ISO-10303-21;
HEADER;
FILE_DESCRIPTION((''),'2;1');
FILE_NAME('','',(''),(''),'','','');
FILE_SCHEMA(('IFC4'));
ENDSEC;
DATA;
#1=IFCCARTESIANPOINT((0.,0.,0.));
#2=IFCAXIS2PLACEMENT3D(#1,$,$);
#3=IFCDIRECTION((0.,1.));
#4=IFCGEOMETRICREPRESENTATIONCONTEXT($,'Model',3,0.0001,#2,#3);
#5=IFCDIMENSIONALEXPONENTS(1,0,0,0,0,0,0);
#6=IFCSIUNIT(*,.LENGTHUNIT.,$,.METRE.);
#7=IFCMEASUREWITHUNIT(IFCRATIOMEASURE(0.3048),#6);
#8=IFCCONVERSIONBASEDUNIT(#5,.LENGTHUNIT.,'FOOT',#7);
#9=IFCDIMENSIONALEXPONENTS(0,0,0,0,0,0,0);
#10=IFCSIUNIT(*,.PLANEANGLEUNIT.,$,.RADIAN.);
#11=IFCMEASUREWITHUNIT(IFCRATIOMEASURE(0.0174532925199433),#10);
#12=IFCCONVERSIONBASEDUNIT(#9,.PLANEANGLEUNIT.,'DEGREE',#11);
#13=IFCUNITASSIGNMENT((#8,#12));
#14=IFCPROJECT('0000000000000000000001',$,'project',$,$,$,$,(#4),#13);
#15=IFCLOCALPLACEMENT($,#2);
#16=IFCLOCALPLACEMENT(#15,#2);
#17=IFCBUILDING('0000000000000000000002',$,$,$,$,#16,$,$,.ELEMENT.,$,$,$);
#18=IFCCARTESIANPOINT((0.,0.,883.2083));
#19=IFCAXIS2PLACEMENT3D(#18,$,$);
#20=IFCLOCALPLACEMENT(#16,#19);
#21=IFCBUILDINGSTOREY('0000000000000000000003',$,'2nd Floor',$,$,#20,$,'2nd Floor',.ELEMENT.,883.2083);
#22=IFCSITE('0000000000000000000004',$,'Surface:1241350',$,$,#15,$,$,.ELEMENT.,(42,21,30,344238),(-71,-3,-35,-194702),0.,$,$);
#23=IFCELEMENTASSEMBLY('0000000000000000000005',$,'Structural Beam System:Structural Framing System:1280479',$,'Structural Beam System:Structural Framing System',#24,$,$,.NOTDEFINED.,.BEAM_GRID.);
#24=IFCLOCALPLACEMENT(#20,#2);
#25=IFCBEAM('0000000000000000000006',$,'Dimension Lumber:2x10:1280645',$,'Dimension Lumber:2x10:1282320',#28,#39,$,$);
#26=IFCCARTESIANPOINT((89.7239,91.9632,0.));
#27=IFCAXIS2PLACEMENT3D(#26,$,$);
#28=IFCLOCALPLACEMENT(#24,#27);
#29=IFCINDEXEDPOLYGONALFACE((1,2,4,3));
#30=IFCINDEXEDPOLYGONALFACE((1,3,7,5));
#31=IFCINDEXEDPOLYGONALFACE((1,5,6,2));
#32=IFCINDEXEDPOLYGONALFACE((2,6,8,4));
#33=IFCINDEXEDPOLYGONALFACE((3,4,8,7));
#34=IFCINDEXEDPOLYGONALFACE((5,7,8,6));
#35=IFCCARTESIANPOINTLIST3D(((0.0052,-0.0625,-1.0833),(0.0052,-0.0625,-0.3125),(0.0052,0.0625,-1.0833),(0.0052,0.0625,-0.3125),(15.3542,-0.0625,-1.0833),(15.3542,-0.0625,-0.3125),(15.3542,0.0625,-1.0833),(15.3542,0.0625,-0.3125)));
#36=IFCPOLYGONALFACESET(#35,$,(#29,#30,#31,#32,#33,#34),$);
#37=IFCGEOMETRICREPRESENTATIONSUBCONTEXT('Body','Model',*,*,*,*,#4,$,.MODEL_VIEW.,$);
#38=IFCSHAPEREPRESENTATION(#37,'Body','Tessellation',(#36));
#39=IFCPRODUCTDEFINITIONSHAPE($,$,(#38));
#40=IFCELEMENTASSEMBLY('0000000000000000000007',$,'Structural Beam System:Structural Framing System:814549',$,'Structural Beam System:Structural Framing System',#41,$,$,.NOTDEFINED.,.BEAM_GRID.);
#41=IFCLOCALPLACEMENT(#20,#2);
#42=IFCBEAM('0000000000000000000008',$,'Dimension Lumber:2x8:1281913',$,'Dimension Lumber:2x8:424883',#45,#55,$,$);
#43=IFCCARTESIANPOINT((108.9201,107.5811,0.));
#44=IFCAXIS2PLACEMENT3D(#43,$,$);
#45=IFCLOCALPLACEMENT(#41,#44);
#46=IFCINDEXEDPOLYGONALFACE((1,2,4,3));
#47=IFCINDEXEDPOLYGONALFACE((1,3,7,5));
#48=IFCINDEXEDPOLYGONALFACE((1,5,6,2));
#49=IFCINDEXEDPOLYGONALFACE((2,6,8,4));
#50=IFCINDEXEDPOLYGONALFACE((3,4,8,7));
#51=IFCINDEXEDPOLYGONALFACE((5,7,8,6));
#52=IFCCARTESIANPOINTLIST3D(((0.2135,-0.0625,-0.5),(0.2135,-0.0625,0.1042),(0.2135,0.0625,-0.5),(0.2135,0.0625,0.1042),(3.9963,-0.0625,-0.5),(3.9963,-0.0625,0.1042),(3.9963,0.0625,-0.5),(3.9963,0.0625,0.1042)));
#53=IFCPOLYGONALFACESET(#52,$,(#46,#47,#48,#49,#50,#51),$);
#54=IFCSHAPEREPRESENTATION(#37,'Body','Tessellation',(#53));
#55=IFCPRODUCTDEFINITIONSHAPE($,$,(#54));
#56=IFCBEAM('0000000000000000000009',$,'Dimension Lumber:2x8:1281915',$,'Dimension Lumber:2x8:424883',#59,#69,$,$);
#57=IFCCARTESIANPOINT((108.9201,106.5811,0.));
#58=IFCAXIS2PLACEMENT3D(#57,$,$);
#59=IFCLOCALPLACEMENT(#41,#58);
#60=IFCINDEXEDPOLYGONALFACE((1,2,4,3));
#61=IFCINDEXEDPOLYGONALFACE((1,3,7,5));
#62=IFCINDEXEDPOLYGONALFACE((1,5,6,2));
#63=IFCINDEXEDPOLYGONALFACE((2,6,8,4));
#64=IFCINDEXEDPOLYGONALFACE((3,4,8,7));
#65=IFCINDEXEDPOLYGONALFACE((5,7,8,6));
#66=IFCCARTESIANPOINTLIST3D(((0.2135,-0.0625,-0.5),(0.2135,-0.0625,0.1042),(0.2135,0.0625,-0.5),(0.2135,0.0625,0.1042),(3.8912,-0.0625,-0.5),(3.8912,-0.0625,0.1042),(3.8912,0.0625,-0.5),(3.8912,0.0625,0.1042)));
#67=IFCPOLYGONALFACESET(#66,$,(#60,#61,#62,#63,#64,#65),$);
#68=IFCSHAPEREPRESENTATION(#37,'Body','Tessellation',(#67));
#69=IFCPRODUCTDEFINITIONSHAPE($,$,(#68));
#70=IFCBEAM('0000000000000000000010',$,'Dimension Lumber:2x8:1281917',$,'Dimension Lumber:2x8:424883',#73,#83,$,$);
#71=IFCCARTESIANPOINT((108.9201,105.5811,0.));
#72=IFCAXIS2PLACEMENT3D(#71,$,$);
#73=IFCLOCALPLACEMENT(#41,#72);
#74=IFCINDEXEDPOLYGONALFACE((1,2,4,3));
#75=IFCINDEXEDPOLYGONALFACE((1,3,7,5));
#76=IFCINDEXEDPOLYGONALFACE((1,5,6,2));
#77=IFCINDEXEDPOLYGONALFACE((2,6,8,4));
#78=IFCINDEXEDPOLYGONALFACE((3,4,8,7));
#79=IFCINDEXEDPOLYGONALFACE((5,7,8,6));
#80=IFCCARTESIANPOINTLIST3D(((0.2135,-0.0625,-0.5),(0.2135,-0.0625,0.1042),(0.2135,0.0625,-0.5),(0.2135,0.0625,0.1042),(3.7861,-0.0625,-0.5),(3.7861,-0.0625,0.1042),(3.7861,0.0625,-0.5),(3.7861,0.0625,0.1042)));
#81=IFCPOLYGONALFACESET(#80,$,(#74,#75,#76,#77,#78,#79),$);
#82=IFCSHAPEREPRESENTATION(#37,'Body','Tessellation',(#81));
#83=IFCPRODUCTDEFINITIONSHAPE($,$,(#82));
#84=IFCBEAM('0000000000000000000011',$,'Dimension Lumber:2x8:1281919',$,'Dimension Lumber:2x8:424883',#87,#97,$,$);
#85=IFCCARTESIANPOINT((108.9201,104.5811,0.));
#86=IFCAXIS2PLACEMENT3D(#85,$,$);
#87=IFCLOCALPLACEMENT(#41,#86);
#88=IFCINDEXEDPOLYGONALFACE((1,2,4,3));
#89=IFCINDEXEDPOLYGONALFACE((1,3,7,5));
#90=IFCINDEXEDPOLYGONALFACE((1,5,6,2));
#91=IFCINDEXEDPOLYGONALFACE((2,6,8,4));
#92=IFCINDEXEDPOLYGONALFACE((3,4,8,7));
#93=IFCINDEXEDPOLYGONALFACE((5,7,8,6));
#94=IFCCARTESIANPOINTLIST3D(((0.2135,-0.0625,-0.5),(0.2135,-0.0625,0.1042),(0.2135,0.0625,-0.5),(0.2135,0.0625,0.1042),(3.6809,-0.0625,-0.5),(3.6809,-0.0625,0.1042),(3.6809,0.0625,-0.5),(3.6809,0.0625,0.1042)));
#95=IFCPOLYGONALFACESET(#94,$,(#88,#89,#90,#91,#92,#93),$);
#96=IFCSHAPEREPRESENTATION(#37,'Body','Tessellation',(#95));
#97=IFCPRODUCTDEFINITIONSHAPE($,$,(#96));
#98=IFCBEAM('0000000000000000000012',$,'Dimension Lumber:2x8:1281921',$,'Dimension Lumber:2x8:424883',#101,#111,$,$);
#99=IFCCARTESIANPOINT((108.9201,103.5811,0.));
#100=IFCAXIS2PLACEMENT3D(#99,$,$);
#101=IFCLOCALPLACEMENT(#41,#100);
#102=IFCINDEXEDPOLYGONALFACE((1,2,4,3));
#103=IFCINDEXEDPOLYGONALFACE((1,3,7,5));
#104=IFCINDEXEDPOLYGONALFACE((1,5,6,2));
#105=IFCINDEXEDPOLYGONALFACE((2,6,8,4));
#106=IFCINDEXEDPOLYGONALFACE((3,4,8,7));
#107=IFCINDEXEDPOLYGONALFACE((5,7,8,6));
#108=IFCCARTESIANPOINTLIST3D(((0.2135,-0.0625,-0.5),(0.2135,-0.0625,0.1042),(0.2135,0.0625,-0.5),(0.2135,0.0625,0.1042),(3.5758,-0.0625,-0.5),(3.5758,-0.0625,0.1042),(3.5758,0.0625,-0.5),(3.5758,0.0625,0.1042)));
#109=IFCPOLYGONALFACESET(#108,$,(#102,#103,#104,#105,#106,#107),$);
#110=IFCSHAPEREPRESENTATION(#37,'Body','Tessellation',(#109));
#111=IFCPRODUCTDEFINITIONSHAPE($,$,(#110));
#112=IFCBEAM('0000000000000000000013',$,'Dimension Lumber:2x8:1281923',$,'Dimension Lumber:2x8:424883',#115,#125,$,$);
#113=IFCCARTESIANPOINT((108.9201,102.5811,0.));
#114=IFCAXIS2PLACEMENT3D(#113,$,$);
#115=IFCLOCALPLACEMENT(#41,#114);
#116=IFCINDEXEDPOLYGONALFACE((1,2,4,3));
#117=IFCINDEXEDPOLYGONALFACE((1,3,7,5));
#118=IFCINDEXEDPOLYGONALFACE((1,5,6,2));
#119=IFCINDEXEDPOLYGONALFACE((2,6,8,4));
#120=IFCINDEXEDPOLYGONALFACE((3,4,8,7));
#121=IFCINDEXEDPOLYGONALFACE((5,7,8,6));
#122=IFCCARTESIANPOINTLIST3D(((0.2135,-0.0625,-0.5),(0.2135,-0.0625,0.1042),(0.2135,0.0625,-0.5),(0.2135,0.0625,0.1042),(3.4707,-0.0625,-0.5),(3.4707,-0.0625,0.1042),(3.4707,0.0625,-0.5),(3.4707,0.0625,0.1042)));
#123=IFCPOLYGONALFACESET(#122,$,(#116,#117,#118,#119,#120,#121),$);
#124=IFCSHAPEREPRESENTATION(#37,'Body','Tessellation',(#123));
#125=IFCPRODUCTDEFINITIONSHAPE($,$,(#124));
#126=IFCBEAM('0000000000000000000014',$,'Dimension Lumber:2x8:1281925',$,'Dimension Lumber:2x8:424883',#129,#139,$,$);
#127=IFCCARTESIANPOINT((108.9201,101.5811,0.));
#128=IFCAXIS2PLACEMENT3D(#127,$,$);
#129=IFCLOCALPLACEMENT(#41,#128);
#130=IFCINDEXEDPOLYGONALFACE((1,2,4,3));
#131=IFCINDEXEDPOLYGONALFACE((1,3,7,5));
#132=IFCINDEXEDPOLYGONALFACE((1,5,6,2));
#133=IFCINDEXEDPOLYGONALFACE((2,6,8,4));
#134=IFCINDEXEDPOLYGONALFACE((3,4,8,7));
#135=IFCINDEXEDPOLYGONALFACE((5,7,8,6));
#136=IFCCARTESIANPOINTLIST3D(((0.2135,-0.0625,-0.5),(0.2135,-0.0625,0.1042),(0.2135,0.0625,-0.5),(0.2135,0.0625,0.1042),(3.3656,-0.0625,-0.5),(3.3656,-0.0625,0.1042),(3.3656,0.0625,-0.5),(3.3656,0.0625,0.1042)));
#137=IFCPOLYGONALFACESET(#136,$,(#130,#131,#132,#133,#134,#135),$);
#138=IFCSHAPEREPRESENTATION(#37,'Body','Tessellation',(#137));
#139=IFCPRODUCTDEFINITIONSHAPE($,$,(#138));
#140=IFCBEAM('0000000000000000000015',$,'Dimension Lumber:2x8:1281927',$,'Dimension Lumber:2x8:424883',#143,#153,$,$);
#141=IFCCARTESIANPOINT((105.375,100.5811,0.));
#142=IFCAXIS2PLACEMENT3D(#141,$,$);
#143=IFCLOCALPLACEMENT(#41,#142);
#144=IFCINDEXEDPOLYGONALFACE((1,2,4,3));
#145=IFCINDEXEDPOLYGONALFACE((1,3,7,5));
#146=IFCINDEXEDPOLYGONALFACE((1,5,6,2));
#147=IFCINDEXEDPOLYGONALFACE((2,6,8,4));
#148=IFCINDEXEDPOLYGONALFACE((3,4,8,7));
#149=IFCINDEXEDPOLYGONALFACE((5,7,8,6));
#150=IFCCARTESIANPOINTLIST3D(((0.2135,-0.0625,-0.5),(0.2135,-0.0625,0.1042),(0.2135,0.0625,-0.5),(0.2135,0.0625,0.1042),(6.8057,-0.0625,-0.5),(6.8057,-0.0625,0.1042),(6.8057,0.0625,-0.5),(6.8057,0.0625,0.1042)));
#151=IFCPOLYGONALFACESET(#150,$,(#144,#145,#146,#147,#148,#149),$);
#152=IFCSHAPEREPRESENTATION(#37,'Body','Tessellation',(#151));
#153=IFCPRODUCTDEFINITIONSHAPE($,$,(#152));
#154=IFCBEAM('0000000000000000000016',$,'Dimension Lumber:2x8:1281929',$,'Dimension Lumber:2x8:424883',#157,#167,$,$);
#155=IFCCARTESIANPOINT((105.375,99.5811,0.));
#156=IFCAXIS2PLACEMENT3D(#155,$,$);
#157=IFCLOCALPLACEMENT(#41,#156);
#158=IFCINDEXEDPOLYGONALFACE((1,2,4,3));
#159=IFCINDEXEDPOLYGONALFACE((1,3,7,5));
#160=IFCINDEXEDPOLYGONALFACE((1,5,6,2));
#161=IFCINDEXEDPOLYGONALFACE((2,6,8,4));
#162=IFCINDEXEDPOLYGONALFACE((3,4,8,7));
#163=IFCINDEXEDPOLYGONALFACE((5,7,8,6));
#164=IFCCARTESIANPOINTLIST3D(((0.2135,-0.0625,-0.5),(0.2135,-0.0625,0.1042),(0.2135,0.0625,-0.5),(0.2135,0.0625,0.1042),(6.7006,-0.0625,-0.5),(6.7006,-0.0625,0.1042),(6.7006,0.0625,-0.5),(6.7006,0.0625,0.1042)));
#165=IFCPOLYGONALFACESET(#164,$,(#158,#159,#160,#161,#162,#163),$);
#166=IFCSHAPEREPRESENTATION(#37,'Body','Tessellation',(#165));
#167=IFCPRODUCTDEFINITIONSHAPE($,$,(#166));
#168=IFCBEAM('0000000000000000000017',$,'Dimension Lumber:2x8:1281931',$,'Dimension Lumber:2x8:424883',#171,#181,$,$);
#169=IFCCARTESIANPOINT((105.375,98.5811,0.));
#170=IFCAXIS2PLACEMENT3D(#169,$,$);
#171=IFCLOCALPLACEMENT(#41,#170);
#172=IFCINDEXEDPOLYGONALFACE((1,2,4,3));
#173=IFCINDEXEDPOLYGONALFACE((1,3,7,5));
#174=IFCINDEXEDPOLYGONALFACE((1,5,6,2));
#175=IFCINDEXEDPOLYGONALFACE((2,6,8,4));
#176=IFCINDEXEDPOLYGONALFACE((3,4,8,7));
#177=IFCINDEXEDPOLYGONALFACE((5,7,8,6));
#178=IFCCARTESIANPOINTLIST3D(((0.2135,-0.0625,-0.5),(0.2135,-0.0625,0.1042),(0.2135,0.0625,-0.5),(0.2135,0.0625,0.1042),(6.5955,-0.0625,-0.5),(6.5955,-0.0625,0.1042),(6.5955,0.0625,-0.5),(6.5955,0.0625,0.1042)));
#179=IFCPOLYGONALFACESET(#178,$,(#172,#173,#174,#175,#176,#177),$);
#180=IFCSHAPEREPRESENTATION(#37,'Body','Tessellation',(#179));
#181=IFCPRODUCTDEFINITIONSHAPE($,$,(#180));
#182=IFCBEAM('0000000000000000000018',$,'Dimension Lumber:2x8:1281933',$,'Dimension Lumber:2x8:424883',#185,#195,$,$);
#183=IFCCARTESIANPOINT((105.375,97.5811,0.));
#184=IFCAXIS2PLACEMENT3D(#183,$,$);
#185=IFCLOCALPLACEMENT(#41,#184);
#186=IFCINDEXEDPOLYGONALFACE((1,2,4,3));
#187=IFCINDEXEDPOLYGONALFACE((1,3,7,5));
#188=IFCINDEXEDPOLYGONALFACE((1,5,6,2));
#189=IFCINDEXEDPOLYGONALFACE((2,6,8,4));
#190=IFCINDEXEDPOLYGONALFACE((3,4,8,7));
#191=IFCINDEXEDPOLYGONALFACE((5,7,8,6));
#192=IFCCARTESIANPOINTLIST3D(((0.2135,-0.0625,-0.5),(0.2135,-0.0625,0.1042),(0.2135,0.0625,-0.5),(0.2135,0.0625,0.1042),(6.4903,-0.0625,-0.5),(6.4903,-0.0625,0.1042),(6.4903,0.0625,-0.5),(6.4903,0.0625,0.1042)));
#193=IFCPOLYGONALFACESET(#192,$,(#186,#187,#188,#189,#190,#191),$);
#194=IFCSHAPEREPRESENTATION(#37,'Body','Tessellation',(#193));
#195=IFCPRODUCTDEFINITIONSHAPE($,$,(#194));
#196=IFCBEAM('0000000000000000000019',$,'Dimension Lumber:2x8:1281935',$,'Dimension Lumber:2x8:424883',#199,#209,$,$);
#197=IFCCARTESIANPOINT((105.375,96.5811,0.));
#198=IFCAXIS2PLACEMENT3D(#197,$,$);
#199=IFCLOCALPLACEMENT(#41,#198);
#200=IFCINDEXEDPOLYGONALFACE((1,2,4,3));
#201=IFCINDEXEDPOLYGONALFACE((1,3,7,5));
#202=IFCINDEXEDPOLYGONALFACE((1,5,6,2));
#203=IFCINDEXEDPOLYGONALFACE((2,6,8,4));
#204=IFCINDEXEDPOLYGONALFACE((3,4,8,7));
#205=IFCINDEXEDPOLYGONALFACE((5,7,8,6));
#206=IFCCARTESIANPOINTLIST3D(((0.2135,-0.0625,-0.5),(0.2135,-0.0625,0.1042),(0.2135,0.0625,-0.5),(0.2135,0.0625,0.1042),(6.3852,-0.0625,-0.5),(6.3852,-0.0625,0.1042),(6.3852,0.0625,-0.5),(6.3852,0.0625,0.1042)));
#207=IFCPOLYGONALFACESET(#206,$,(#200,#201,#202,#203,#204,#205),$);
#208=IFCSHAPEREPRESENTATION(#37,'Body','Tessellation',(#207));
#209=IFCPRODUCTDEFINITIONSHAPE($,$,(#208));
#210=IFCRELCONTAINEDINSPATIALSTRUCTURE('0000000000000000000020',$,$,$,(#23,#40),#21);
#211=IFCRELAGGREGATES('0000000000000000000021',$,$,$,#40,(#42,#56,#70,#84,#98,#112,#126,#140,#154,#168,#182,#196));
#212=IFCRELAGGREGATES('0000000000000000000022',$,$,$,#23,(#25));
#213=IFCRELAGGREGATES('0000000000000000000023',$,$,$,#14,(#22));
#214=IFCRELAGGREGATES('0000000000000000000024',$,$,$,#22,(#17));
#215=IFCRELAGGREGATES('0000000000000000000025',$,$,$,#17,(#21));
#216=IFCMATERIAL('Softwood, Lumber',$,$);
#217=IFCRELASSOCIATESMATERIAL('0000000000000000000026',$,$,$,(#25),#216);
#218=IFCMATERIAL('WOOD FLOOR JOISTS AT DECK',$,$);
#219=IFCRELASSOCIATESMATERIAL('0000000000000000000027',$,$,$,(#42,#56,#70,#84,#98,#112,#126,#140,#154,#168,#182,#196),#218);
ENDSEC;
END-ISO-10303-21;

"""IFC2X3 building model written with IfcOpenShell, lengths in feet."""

from ifc_helpers import new_model, entity, si_unit, converted_unit, direction, frame, frame_2d, origin, origin_2d_with_axis, place, context, subcontext, project, spatial, rectangle, extrude, material, element, aggregate, save


model = new_model("IFC2X3")

# Units and contexts
model_context = context("Model", 3, precision=0.0001, world=origin(), true_north=direction((0.0, 1.0)))
body_context = subcontext(model_context, "Body", "Model", "MODEL_VIEW")
ifc_project = project(units=[converted_unit("LENGTHUNIT", "FOOT", entity("IfcRatioMeasure", 0.3048), si_unit("LENGTHUNIT", "METRE"), dimensions=[1, 0, 0, 0, 0, 0, 0]), converted_unit("PLANEANGLEUNIT", "DEGREE", entity("IfcRatioMeasure", 0.0174532925199433), si_unit("PLANEANGLEUNIT", "RADIAN"), dimensions=[0, 0, 0, 0, 0, 0, 0])], contexts=[model_context])

# Site, building, storey
site_placement = place(None, origin())
site = spatial("IfcSite", under=ifc_project, at=site_placement, Name="Surface:1241350", CompositionType="ELEMENT", RefLatitude=(42, 21, 30, 344238), RefLongitude=(-71, -3, -35, -194702), RefElevation=0.0)
building_placement = place(site_placement, origin())
building = spatial("IfcBuilding", under=site, at=building_placement, CompositionType="ELEMENT")
storey_placement = place(building_placement, frame((0.0, 0.0, 883.2083)))
storey = spatial("IfcBuildingStorey", under=building, at=storey_placement, Name="2nd Floor", LongName="2nd Floor", CompositionType="ELEMENT", Elevation=883.2083)

# Element assemblies, beams
assembly_1_placement = place(storey_placement, origin())
assembly_1 = element("IfcElementAssembly", 1, at=assembly_1_placement, inside=storey, Name="Structural Beam System:Structural Framing System:1280479", ObjectType="Structural Beam System:Structural Framing System", AssemblyPlace="NOTDEFINED", PredefinedType="BEAM_GRID")
ifc_material_1 = material(Name="Softwood, Lumber")
beam_1_placement = place(assembly_1_placement, frame((89.7239, 91.9632, 0.0)))
beam_1 = element("IfcBeam", 2, at=beam_1_placement, material=ifc_material_1, Name="Dimension Lumber:2x10:1280645", ObjectType="Dimension Lumber:2x10:1282320", context=body_context, shape_type="SweptSolid", body=[
    extrude(rectangle(XDim=0.7708, YDim=0.125, at=frame_2d((0.0, 0.0), x_axis=(1.0, 0.0))), frame((0.0052, 0.0, -0.6979), z_axis=(1.0, 0.0, 0.0), x_axis=(0.0, 0.0, -1.0)), (0.0, 0.0, 1.0), 15.349),
])
assembly_2_placement = place(storey_placement, origin())
assembly_2 = element("IfcElementAssembly", 3, at=assembly_2_placement, inside=storey, Name="Structural Beam System:Structural Framing System:814549", ObjectType="Structural Beam System:Structural Framing System", AssemblyPlace="NOTDEFINED", PredefinedType="BEAM_GRID")
ifc_material_2 = material(Name="WOOD FLOOR JOISTS AT DECK")
beam_2_placement = place(assembly_2_placement, frame((108.9201, 107.5811, 0.0)))
beam_2 = element("IfcBeam", 4, at=beam_2_placement, material=ifc_material_2, Name="Dimension Lumber:2x8:1281913", ObjectType="Dimension Lumber:2x8:424883", context=body_context, shape_type="SweptSolid", body=[
    extrude(rectangle(XDim=0.6042, YDim=0.125, at=origin_2d_with_axis()), frame((0.2135, 0.0, -0.1979), z_axis=(1.0, 0.0, 0.0), x_axis=(0.0, 0.0, -1.0)), (0.0, 0.0, 1.0), 3.7827),
])
beam_3_placement = place(assembly_2_placement, frame((108.9201, 106.5811, 0.0)))
beam_3 = element("IfcBeam", 5, at=beam_3_placement, material=ifc_material_2, Name="Dimension Lumber:2x8:1281915", ObjectType="Dimension Lumber:2x8:424883", context=body_context, shape_type="SweptSolid", body=[
    extrude(rectangle(XDim=0.6042, YDim=0.125, at=origin_2d_with_axis()), frame((0.2135, 0.0, -0.1979), z_axis=(1.0, 0.0, 0.0), x_axis=(0.0, 0.0, -1.0)), (0.0, 0.0, 1.0), 3.6776),
])
beam_4_placement = place(assembly_2_placement, frame((108.9201, 105.5811, 0.0)))
beam_4 = element("IfcBeam", 6, at=beam_4_placement, material=ifc_material_2, Name="Dimension Lumber:2x8:1281917", ObjectType="Dimension Lumber:2x8:424883", context=body_context, shape_type="SweptSolid", body=[
    extrude(rectangle(XDim=0.6042, YDim=0.125, at=origin_2d_with_axis()), frame((0.2135, 0.0, -0.1979), z_axis=(1.0, 0.0, 0.0), x_axis=(0.0, 0.0, -1.0)), (0.0, 0.0, 1.0), 3.5725),
])
beam_5_placement = place(assembly_2_placement, frame((108.9201, 104.5811, 0.0)))
beam_5 = element("IfcBeam", 7, at=beam_5_placement, material=ifc_material_2, Name="Dimension Lumber:2x8:1281919", ObjectType="Dimension Lumber:2x8:424883", context=body_context, shape_type="SweptSolid", body=[
    extrude(rectangle(XDim=0.6042, YDim=0.125, at=origin_2d_with_axis()), frame((0.2135, 0.0, -0.1979), z_axis=(1.0, 0.0, 0.0), x_axis=(0.0, 0.0, -1.0)), (0.0, 0.0, 1.0), 3.4674),
])
beam_6_placement = place(assembly_2_placement, frame((108.9201, 103.5811, 0.0)))
beam_6 = element("IfcBeam", 8, at=beam_6_placement, material=ifc_material_2, Name="Dimension Lumber:2x8:1281921", ObjectType="Dimension Lumber:2x8:424883", context=body_context, shape_type="SweptSolid", body=[
    extrude(rectangle(XDim=0.6042, YDim=0.125, at=origin_2d_with_axis()), frame((0.2135, 0.0, -0.1979), z_axis=(1.0, 0.0, 0.0), x_axis=(0.0, 0.0, -1.0)), (0.0, 0.0, 1.0), 3.3623),
])
beam_7_placement = place(assembly_2_placement, frame((108.9201, 102.5811, 0.0)))
beam_7 = element("IfcBeam", 9, at=beam_7_placement, material=ifc_material_2, Name="Dimension Lumber:2x8:1281923", ObjectType="Dimension Lumber:2x8:424883", context=body_context, shape_type="SweptSolid", body=[
    extrude(rectangle(XDim=0.6042, YDim=0.125, at=origin_2d_with_axis()), frame((0.2135, 0.0, -0.1979), z_axis=(1.0, 0.0, 0.0), x_axis=(0.0, 0.0, -1.0)), (0.0, 0.0, 1.0), 3.2572),
])
beam_8_placement = place(assembly_2_placement, frame((108.9201, 101.5811, 0.0)))
beam_8 = element("IfcBeam", 10, at=beam_8_placement, material=ifc_material_2, Name="Dimension Lumber:2x8:1281925", ObjectType="Dimension Lumber:2x8:424883", context=body_context, shape_type="SweptSolid", body=[
    extrude(rectangle(XDim=0.6042, YDim=0.125, at=origin_2d_with_axis()), frame((0.2135, 0.0, -0.1979), z_axis=(1.0, 0.0, 0.0), x_axis=(0.0, 0.0, -1.0)), (0.0, 0.0, 1.0), 3.1521),
])
beam_9_placement = place(assembly_2_placement, frame((105.375, 100.5811, 0.0)))
beam_9 = element("IfcBeam", 11, at=beam_9_placement, material=ifc_material_2, Name="Dimension Lumber:2x8:1281927", ObjectType="Dimension Lumber:2x8:424883", context=body_context, shape_type="SweptSolid", body=[
    extrude(rectangle(XDim=0.6042, YDim=0.125, at=origin_2d_with_axis()), frame((0.2135, 0.0, -0.1979), z_axis=(1.0, 0.0, 0.0), x_axis=(0.0, 0.0, -1.0)), (0.0, 0.0, 1.0), 6.5921),
])
beam_10_placement = place(assembly_2_placement, frame((105.375, 99.5811, 0.0)))
beam_10 = element("IfcBeam", 12, at=beam_10_placement, material=ifc_material_2, Name="Dimension Lumber:2x8:1281929", ObjectType="Dimension Lumber:2x8:424883", context=body_context, shape_type="SweptSolid", body=[
    extrude(rectangle(XDim=0.6042, YDim=0.125, at=origin_2d_with_axis()), frame((0.2135, 0.0, -0.1979), z_axis=(1.0, 0.0, 0.0), x_axis=(0.0, 0.0, -1.0)), (0.0, 0.0, 1.0), 6.487),
])
beam_11_placement = place(assembly_2_placement, frame((105.375, 98.5811, 0.0)))
beam_11 = element("IfcBeam", 13, at=beam_11_placement, material=ifc_material_2, Name="Dimension Lumber:2x8:1281931", ObjectType="Dimension Lumber:2x8:424883", context=body_context, shape_type="SweptSolid", body=[
    extrude(rectangle(XDim=0.6042, YDim=0.125, at=origin_2d_with_axis()), frame((0.2135, 0.0, -0.1979), z_axis=(1.0, 0.0, 0.0), x_axis=(0.0, 0.0, -1.0)), (0.0, 0.0, 1.0), 6.3819),
])
beam_12_placement = place(assembly_2_placement, frame((105.375, 97.5811, 0.0)))
beam_12 = element("IfcBeam", 14, at=beam_12_placement, material=ifc_material_2, Name="Dimension Lumber:2x8:1281933", ObjectType="Dimension Lumber:2x8:424883", context=body_context, shape_type="SweptSolid", body=[
    extrude(rectangle(XDim=0.6042, YDim=0.125, at=origin_2d_with_axis()), frame((0.2135, 0.0, -0.1979), z_axis=(1.0, 0.0, 0.0), x_axis=(0.0, 0.0, -1.0)), (0.0, 0.0, 1.0), 6.2768),
])
beam_13_placement = place(assembly_2_placement, frame((105.375, 96.5811, 0.0)))
beam_13 = element("IfcBeam", 15, at=beam_13_placement, material=ifc_material_2, Name="Dimension Lumber:2x8:1281935", ObjectType="Dimension Lumber:2x8:424883", context=body_context, shape_type="SweptSolid", body=[
    extrude(rectangle(XDim=0.6042, YDim=0.125, at=origin_2d_with_axis()), frame((0.2135, 0.0, -0.1979), z_axis=(1.0, 0.0, 0.0), x_axis=(0.0, 0.0, -1.0)), (0.0, 0.0, 1.0), 6.1717),
])
aggregate(assembly_2, [beam_2, beam_3, beam_4, beam_5, beam_6, beam_7, beam_8, beam_9, beam_10, beam_11, beam_12, beam_13])

aggregate(assembly_1, [beam_1])

save(model, "model.ifc")
